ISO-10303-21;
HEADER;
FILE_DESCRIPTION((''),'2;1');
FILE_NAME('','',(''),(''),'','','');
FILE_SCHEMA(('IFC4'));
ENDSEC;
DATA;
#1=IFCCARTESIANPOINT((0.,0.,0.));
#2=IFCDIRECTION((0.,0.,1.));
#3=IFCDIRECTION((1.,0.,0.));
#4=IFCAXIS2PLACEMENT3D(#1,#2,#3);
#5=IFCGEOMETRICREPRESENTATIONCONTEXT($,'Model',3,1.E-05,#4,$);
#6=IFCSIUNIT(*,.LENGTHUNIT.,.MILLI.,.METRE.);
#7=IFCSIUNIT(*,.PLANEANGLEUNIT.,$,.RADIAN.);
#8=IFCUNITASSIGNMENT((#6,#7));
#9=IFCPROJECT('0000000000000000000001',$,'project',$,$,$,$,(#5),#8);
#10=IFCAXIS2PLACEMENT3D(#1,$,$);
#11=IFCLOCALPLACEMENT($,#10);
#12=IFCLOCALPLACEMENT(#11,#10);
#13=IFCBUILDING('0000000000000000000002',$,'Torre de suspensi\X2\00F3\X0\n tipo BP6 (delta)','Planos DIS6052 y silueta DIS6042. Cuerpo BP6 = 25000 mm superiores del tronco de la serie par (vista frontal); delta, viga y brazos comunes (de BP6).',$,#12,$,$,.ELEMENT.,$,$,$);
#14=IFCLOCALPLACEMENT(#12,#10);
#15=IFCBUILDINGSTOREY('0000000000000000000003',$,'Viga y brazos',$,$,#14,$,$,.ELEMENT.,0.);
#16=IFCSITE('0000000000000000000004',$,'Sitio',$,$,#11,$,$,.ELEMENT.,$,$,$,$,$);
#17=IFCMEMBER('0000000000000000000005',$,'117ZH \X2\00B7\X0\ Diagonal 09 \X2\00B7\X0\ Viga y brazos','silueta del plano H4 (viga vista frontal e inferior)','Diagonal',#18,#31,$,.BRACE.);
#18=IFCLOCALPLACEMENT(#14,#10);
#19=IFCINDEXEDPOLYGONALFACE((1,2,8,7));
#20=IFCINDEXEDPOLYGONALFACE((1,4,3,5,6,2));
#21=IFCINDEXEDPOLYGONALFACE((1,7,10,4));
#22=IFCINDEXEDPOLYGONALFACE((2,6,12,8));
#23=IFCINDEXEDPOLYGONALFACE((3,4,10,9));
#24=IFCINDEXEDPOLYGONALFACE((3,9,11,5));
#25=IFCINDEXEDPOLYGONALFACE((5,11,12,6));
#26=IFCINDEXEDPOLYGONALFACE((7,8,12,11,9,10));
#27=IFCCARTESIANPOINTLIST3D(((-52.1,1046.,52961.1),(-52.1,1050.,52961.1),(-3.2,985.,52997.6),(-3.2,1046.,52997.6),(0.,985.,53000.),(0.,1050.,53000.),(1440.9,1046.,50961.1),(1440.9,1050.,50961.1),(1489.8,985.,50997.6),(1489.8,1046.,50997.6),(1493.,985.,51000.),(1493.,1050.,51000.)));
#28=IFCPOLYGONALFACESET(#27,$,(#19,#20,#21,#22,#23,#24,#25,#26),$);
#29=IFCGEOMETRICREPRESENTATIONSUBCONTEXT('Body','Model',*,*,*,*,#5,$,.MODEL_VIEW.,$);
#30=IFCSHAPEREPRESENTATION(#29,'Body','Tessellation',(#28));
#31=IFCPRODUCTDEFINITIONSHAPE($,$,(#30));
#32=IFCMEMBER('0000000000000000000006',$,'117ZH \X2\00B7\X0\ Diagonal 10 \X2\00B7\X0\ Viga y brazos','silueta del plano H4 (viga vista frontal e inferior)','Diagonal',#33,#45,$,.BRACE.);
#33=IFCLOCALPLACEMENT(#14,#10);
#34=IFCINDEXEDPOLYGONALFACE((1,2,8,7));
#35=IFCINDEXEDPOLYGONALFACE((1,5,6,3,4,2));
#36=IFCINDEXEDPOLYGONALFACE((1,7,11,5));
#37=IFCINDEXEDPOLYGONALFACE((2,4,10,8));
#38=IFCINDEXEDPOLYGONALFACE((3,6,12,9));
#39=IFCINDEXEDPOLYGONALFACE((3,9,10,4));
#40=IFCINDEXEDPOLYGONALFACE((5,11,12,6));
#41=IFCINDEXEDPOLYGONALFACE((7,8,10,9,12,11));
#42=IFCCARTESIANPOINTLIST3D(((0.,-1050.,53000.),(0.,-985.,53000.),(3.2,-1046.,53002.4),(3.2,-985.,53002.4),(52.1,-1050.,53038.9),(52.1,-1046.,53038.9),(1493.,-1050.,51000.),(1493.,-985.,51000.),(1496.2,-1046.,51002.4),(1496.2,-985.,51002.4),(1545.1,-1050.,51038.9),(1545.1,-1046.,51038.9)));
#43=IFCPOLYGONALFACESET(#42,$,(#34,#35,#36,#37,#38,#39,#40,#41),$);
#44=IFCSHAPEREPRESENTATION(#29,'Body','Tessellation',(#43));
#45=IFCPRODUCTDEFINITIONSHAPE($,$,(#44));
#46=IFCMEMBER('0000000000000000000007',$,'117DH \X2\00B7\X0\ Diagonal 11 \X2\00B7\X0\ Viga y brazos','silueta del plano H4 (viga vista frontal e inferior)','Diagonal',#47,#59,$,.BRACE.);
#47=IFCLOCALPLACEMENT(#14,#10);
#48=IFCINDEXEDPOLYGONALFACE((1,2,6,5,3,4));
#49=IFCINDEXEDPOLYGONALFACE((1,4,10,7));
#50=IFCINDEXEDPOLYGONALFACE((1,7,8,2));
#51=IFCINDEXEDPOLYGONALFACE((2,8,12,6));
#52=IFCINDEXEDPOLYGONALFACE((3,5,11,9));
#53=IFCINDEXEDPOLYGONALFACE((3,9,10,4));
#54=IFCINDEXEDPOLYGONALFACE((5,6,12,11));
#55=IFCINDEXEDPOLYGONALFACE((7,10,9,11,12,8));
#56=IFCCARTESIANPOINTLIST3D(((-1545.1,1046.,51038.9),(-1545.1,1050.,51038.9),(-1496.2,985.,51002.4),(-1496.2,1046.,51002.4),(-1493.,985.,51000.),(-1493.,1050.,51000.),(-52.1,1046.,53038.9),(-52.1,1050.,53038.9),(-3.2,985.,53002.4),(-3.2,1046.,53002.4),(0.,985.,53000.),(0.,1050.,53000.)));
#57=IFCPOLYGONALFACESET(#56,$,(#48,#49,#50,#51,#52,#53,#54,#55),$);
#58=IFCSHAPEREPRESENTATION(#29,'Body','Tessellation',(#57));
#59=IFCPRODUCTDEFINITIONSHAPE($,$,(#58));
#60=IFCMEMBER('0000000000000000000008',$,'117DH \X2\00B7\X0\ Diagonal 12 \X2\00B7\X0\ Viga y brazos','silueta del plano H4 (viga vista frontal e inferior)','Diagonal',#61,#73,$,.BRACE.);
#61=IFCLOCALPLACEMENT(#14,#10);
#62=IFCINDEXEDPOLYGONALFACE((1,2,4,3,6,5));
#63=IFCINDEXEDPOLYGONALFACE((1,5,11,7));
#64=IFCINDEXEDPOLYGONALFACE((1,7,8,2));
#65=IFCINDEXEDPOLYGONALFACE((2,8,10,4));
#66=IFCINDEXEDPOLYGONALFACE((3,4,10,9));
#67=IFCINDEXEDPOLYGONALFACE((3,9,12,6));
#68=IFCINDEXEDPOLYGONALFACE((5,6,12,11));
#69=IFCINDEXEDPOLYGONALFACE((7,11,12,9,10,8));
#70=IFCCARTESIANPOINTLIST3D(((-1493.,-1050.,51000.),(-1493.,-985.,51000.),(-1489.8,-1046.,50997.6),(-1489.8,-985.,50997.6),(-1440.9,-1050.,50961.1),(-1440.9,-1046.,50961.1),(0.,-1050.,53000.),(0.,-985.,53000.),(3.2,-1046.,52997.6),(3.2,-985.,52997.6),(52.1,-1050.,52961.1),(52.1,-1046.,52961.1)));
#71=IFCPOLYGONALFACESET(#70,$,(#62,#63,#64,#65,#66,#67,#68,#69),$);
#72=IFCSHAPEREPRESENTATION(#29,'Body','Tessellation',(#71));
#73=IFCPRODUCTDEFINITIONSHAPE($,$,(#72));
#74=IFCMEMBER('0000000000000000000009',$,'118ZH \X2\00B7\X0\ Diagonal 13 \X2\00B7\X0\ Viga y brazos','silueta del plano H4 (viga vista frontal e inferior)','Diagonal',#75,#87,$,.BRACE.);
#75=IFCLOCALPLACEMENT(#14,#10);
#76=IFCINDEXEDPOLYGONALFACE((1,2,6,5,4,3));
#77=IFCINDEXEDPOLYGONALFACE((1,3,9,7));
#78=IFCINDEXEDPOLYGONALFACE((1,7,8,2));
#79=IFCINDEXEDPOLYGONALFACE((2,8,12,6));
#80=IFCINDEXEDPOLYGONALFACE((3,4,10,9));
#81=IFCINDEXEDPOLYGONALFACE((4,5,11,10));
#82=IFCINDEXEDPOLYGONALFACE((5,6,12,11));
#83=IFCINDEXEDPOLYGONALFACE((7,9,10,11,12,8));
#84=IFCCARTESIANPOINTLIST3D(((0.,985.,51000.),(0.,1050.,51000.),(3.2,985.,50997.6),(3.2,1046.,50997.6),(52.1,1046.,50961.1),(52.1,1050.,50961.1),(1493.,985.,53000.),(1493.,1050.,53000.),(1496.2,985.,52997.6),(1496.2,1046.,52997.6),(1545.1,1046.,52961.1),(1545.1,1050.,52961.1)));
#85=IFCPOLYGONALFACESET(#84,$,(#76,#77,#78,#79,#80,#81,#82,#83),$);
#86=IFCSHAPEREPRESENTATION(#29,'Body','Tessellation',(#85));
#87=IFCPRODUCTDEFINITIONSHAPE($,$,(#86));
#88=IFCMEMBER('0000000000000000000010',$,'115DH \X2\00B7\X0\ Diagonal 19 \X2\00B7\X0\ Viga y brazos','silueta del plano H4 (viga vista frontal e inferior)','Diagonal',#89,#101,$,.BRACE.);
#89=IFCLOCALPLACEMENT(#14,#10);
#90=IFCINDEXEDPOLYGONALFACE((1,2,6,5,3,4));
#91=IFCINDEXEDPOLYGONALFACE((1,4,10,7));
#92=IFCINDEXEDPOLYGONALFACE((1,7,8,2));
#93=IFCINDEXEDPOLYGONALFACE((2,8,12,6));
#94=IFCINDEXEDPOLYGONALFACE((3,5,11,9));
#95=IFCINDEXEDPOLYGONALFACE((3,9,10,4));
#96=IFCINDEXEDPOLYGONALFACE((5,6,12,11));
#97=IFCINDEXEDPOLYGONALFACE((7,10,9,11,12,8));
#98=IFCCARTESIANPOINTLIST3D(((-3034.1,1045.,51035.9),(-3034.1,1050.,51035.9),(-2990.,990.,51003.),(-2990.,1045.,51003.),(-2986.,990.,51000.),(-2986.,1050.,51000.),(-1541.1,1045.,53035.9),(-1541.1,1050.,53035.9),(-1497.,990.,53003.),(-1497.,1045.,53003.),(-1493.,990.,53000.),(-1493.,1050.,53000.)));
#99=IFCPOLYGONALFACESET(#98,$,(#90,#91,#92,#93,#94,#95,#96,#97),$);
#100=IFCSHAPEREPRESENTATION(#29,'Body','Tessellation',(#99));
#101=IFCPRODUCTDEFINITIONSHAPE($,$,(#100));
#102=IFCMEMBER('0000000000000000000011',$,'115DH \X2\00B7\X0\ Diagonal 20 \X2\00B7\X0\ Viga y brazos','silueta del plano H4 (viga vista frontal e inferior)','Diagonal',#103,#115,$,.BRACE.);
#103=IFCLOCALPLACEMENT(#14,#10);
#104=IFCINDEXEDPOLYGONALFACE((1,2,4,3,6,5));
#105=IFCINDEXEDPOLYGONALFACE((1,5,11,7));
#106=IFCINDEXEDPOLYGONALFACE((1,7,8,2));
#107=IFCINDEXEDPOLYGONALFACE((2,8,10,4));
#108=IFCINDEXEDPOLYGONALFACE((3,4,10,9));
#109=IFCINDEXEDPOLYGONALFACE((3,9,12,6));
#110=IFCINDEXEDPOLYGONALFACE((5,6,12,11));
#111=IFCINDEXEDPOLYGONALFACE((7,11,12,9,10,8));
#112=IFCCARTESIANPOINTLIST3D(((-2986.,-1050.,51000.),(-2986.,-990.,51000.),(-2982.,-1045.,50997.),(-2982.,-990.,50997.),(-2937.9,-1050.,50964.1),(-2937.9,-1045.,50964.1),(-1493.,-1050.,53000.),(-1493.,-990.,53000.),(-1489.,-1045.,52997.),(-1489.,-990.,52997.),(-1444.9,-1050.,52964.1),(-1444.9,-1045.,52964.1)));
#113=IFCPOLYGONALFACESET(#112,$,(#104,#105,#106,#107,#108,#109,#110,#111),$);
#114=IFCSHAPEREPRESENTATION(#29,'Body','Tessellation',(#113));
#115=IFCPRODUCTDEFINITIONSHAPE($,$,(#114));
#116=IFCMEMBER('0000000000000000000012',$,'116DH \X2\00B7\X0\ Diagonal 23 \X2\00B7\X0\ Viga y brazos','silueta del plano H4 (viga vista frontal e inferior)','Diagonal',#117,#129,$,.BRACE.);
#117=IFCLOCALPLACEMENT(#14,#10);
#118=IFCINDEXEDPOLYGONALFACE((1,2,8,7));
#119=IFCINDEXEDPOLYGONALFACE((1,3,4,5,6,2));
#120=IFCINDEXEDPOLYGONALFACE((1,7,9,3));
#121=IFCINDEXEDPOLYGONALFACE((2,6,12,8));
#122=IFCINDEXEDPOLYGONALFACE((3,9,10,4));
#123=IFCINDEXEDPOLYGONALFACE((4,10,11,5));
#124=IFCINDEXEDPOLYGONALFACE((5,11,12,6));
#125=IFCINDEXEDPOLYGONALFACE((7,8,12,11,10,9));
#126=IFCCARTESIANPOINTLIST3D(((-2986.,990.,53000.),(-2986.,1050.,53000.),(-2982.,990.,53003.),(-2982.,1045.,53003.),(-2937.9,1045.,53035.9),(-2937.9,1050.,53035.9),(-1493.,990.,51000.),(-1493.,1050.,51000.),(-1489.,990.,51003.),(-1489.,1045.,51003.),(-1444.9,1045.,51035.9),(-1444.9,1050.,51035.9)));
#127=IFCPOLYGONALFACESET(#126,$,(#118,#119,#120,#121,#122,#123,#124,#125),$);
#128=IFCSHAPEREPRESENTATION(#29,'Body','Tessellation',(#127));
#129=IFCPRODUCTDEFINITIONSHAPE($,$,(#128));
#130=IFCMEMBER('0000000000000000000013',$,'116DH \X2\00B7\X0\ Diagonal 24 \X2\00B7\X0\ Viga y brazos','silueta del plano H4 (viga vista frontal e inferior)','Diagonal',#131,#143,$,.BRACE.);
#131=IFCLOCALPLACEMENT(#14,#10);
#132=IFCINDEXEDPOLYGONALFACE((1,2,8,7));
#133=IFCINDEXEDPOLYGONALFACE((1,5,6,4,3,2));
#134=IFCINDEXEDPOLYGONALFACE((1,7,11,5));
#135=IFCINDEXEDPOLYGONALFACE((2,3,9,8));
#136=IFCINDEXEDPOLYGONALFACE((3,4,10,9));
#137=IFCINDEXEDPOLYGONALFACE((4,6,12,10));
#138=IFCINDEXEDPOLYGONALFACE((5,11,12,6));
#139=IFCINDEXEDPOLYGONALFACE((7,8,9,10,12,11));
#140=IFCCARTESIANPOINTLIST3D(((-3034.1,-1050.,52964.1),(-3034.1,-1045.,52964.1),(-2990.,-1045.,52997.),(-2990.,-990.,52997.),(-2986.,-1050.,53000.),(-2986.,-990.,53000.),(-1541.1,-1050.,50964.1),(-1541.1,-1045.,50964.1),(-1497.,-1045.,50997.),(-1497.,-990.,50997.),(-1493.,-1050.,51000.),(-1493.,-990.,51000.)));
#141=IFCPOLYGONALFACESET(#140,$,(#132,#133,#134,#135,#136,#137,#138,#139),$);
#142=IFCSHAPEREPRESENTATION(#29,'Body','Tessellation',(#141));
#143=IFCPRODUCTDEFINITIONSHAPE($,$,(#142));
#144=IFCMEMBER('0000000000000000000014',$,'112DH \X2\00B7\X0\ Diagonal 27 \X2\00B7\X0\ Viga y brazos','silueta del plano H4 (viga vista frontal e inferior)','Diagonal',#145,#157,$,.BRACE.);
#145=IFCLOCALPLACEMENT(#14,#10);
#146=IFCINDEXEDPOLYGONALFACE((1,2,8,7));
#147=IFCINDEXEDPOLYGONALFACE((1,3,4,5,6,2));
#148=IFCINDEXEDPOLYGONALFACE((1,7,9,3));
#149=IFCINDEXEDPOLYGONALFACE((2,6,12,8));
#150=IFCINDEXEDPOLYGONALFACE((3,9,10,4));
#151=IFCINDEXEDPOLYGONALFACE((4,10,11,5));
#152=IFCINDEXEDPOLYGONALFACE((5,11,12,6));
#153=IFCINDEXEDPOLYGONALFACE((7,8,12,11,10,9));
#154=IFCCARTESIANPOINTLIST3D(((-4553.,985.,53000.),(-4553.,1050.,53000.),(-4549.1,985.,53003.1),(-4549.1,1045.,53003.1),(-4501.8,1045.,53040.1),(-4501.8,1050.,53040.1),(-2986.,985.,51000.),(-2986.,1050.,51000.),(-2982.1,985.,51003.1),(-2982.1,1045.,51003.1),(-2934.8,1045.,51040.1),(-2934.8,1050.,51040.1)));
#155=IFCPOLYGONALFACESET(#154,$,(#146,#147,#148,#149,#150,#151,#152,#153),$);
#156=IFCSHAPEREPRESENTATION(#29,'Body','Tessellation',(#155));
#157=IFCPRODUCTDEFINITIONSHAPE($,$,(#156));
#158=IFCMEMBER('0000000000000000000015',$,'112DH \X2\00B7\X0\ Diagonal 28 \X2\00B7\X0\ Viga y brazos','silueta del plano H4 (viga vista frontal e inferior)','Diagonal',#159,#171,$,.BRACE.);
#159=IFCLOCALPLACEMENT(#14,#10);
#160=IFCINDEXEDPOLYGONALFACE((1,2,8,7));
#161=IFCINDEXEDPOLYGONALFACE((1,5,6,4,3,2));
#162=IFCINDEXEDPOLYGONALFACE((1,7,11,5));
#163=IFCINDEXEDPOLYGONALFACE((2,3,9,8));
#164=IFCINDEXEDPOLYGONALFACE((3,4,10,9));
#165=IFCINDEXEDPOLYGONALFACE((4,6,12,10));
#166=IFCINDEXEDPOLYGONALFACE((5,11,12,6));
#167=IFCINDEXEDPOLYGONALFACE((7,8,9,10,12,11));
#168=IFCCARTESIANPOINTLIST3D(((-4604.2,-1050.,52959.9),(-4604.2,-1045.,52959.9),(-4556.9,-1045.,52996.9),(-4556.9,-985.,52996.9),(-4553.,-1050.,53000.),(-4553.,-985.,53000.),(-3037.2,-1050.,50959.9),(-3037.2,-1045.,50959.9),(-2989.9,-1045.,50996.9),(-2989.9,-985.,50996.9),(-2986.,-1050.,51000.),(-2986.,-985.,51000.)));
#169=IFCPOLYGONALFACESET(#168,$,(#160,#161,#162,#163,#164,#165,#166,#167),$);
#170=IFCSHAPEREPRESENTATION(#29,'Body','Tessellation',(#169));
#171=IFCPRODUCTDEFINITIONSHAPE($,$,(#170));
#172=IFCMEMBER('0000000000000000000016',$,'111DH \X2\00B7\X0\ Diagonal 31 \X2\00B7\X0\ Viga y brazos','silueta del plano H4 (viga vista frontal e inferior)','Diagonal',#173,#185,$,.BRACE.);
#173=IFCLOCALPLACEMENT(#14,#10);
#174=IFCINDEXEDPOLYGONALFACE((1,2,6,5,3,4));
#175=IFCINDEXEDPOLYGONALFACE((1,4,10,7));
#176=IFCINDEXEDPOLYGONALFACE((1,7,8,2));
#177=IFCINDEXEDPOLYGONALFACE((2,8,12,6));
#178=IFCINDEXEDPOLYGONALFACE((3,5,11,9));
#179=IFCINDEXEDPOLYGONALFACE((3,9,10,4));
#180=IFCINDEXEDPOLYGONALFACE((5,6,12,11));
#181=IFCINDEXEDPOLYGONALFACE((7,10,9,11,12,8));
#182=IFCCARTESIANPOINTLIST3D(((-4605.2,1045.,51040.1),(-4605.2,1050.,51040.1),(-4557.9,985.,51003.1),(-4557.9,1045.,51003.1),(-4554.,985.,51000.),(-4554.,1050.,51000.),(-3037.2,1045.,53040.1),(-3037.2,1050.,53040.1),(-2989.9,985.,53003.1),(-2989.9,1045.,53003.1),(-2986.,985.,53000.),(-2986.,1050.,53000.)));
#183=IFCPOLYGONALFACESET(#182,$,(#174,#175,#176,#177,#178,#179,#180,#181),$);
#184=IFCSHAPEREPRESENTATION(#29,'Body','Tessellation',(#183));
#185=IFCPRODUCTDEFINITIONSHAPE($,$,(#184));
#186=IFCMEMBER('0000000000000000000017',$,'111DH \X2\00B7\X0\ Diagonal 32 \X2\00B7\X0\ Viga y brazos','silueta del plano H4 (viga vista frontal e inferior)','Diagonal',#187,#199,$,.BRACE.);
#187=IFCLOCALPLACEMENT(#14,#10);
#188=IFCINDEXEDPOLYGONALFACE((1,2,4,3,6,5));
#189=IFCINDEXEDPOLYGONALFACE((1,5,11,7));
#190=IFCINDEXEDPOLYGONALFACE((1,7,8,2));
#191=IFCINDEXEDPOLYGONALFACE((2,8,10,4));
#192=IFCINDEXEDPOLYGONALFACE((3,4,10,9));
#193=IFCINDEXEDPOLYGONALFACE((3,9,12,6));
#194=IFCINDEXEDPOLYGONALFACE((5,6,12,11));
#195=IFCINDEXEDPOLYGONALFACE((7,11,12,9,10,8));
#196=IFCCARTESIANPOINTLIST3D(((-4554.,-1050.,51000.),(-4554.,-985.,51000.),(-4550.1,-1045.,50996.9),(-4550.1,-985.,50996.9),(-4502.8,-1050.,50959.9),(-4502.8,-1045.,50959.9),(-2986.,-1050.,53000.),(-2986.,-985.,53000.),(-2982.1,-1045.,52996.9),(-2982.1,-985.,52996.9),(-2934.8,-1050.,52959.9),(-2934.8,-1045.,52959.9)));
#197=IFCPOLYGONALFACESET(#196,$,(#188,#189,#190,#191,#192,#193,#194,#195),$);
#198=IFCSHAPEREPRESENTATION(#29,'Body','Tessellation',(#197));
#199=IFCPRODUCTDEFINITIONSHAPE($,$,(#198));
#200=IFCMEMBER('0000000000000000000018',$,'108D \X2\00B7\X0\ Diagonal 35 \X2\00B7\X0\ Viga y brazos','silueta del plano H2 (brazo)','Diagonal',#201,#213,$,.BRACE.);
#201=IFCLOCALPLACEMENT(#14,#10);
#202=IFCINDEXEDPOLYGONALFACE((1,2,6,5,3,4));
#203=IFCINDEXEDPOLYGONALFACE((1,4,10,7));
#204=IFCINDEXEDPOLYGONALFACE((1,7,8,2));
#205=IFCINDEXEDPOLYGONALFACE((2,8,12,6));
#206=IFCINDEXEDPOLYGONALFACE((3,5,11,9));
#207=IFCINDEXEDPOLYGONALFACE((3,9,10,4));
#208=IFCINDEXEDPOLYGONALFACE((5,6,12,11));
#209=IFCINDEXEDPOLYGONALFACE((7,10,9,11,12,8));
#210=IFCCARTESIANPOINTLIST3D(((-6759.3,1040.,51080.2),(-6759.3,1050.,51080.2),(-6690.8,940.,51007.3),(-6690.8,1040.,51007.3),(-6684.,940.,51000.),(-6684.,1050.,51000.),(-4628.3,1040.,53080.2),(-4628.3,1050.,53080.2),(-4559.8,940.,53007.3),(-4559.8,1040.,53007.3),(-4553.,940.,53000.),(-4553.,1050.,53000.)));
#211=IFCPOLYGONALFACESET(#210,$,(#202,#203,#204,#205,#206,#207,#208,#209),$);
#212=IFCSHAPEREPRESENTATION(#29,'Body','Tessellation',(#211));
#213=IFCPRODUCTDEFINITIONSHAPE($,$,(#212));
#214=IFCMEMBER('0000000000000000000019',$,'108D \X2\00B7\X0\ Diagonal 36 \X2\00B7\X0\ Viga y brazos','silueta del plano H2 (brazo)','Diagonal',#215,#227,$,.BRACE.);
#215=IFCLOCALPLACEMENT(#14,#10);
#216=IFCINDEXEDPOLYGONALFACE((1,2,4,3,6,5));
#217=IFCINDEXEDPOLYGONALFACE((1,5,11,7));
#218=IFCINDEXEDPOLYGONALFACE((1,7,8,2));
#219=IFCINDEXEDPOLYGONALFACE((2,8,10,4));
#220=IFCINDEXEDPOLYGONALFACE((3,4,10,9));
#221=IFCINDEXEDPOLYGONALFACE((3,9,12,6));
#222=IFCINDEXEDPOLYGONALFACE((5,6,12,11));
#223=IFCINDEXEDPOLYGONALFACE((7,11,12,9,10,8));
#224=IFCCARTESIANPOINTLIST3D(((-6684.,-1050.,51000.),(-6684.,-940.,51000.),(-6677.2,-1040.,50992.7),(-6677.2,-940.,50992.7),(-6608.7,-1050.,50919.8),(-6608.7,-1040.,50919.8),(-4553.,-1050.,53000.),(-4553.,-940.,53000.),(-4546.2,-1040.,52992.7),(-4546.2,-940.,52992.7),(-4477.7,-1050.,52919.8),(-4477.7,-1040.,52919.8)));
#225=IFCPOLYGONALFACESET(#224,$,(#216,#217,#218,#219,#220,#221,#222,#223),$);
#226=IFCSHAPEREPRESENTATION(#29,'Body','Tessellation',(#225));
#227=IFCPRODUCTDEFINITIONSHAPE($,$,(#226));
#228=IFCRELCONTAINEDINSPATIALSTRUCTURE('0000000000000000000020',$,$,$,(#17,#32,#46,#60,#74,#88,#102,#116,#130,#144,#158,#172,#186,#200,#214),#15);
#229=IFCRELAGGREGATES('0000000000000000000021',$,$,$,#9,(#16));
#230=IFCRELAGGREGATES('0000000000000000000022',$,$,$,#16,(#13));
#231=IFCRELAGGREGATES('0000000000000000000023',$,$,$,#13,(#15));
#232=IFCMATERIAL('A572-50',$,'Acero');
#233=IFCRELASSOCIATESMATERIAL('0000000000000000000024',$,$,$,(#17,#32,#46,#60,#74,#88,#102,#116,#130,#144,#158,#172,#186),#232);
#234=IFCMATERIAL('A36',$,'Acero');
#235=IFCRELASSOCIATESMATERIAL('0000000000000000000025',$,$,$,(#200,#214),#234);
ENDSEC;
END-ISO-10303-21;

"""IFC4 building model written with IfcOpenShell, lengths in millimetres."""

from ifc_helpers import new_model, si_unit, frame, frame_2d, origin, origin_with_axes, place, context, subcontext, project, spatial, l_section, extrude, material, element, save


model = new_model("IFC4")

# Units and contexts
model_context = context("Model", 3, precision=1e-05, world=origin_with_axes())
body_context = subcontext(model_context, "Body", "Model", "MODEL_VIEW")
ifc_project = project(units=[si_unit("LENGTHUNIT", "METRE", prefix="MILLI"), si_unit("PLANEANGLEUNIT", "RADIAN")], contexts=[model_context])

# Site, building, storey
site_placement = place(None, origin())
site = spatial("IfcSite", under=ifc_project, at=site_placement, Name="Sitio", CompositionType="ELEMENT")
building_placement = place(site_placement, origin())
building = spatial("IfcBuilding", under=site, at=building_placement, Name="Torre de suspensión tipo BP6 (delta)", Description="Planos DIS6052 y silueta DIS6042. Cuerpo BP6 = 25000 mm superiores del tronco de la serie par (vista frontal); delta, viga y brazos comunes (de BP6).", CompositionType="ELEMENT")
storey_placement = place(building_placement, origin())
storey = spatial("IfcBuildingStorey", under=building, at=storey_placement, Name="Viga y brazos", CompositionType="ELEMENT", Elevation=0.0)

# Members
ifc_material_1 = material(Name="A572-50", Category="Acero")
for number, where, z_axis, x_axis, name in (
    (1, (0.0, 1050.0, 53000.0), (0.598203, 0.0, -0.801344), (0.0, -1.0, 0.0), "117ZH · Diagonal 09 · Viga y brazos"),
    (2, (0.0, -1050.0, 53000.0), (0.598203, 0.0, -0.801344), (0.0, 1.0, 0.0), "117ZH · Diagonal 10 · Viga y brazos"),
    (3, (0.0, 1050.0, 53000.0), (-0.598203, 0.0, -0.801344), (0.0, -1.0, 0.0), "117DH · Diagonal 11 · Viga y brazos"),
    (4, (0.0, -1050.0, 53000.0), (-0.598203, 0.0, -0.801344), (0.0, 1.0, 0.0), "117DH · Diagonal 12 · Viga y brazos"),
    (5, (0.0, 1050.0, 51000.0), (0.598203, 0.0, 0.801344), (0.0, -1.0, 0.0), "118ZH · Diagonal 13 · Viga y brazos"),
):
    element("IfcMember", number, at=place(storey_placement, frame(where, z_axis=z_axis, x_axis=x_axis)), inside=storey, material=ifc_material_1, Name=name, Description="silueta del plano H4 (viga vista frontal e inferior)", ObjectType="Diagonal", PredefinedType="BRACE", context=body_context, shape_type="SweptSolid", body=[
        extrude(l_section(Depth=65.0, Width=65.0, Thickness=4.0, at=frame_2d((32.5, 32.5))), None, (0.0, 0.0, 1.0), 2495.8),
    ])
for number, where, z_axis, x_axis, name in (
    (6, (-1493.0, 1050.0, 53000.0), (-0.598203, 0.0, -0.801344), (0.0, -1.0, 0.0), "115DH · Diagonal 19 · Viga y brazos"),
    (7, (-1493.0, -1050.0, 53000.0), (-0.598203, 0.0, -0.801344), (0.0, 1.0, 0.0), "115DH · Diagonal 20 · Viga y brazos"),
    (8, (-1493.0, 1050.0, 51000.0), (-0.598203, 0.0, 0.801344), (0.0, -1.0, 0.0), "116DH · Diagonal 23 · Viga y brazos"),
    (9, (-1493.0, -1050.0, 51000.0), (-0.598203, 0.0, 0.801344), (0.0, 1.0, 0.0), "116DH · Diagonal 24 · Viga y brazos"),
):
    element("IfcMember", number, at=place(storey_placement, frame(where, z_axis=z_axis, x_axis=x_axis)), inside=storey, material=ifc_material_1, Name=name, Description="silueta del plano H4 (viga vista frontal e inferior)", ObjectType="Diagonal", PredefinedType="BRACE", context=body_context, shape_type="SweptSolid", body=[
        extrude(l_section(Depth=60.0, Width=60.0, Thickness=5.0, at=frame_2d((30.0, 30.0))), None, (0.0, 0.0, 1.0), 2495.8),
    ])
for number, where, z_axis, x_axis, name in (
    (10, (-2986.0, 1050.0, 51000.0), (-0.616743, 0.0, 0.787164), (0.0, -1.0, 0.0), "112DH · Diagonal 27 · Viga y brazos"),
    (11, (-2986.0, -1050.0, 51000.0), (-0.616743, 0.0, 0.787164), (0.0, 1.0, 0.0), "112DH · Diagonal 28 · Viga y brazos"),
):
    element("IfcMember", number, at=place(storey_placement, frame(where, z_axis=z_axis, x_axis=x_axis)), inside=storey, material=ifc_material_1, Name=name, Description="silueta del plano H4 (viga vista frontal e inferior)", ObjectType="Diagonal", PredefinedType="BRACE", context=body_context, shape_type="SweptSolid", body=[
        extrude(l_section(Depth=65.0, Width=65.0, Thickness=5.0, at=frame_2d((32.5, 32.5))), None, (0.0, 0.0, 1.0), 2540.8),
    ])
for number, where, z_axis, x_axis, name in (
    (12, (-2986.0, 1050.0, 53000.0), (-0.616987, 0.0, -0.786973), (0.0, -1.0, 0.0), "111DH · Diagonal 31 · Viga y brazos"),
    (13, (-2986.0, -1050.0, 53000.0), (-0.616987, 0.0, -0.786973), (0.0, 1.0, 0.0), "111DH · Diagonal 32 · Viga y brazos"),
):
    element("IfcMember", number, at=place(storey_placement, frame(where, z_axis=z_axis, x_axis=x_axis)), inside=storey, material=ifc_material_1, Name=name, Description="silueta del plano H4 (viga vista frontal e inferior)", ObjectType="Diagonal", PredefinedType="BRACE", context=body_context, shape_type="SweptSolid", body=[
        extrude(l_section(Depth=65.0, Width=65.0, Thickness=5.0, at=frame_2d((32.5, 32.5))), None, (0.0, 0.0, 1.0), 2541.4),
    ])
ifc_material_2 = material(Name="A36", Category="Acero")
for number, where, z_axis, x_axis, name in (
    (14, (-4553.0, 1050.0, 53000.0), (-0.729164, 0.0, -0.684339), (0.0, -1.0, 0.0), "108D · Diagonal 35 · Viga y brazos"),
    (15, (-4553.0, -1050.0, 53000.0), (-0.729164, 0.0, -0.684339), (0.0, 1.0, 0.0), "108D · Diagonal 36 · Viga y brazos"),
):
    element("IfcMember", number, at=place(storey_placement, frame(where, z_axis=z_axis, x_axis=x_axis)), inside=storey, material=ifc_material_2, Name=name, Description="silueta del plano H2 (brazo)", ObjectType="Diagonal", PredefinedType="BRACE", context=body_context, shape_type="SweptSolid", body=[
        extrude(l_section(Depth=110.0, Width=110.0, Thickness=10.0, at=frame_2d((55.0, 55.0))), None, (0.0, 0.0, 1.0), 2922.5),
    ])

save(model, "model.ifc")
